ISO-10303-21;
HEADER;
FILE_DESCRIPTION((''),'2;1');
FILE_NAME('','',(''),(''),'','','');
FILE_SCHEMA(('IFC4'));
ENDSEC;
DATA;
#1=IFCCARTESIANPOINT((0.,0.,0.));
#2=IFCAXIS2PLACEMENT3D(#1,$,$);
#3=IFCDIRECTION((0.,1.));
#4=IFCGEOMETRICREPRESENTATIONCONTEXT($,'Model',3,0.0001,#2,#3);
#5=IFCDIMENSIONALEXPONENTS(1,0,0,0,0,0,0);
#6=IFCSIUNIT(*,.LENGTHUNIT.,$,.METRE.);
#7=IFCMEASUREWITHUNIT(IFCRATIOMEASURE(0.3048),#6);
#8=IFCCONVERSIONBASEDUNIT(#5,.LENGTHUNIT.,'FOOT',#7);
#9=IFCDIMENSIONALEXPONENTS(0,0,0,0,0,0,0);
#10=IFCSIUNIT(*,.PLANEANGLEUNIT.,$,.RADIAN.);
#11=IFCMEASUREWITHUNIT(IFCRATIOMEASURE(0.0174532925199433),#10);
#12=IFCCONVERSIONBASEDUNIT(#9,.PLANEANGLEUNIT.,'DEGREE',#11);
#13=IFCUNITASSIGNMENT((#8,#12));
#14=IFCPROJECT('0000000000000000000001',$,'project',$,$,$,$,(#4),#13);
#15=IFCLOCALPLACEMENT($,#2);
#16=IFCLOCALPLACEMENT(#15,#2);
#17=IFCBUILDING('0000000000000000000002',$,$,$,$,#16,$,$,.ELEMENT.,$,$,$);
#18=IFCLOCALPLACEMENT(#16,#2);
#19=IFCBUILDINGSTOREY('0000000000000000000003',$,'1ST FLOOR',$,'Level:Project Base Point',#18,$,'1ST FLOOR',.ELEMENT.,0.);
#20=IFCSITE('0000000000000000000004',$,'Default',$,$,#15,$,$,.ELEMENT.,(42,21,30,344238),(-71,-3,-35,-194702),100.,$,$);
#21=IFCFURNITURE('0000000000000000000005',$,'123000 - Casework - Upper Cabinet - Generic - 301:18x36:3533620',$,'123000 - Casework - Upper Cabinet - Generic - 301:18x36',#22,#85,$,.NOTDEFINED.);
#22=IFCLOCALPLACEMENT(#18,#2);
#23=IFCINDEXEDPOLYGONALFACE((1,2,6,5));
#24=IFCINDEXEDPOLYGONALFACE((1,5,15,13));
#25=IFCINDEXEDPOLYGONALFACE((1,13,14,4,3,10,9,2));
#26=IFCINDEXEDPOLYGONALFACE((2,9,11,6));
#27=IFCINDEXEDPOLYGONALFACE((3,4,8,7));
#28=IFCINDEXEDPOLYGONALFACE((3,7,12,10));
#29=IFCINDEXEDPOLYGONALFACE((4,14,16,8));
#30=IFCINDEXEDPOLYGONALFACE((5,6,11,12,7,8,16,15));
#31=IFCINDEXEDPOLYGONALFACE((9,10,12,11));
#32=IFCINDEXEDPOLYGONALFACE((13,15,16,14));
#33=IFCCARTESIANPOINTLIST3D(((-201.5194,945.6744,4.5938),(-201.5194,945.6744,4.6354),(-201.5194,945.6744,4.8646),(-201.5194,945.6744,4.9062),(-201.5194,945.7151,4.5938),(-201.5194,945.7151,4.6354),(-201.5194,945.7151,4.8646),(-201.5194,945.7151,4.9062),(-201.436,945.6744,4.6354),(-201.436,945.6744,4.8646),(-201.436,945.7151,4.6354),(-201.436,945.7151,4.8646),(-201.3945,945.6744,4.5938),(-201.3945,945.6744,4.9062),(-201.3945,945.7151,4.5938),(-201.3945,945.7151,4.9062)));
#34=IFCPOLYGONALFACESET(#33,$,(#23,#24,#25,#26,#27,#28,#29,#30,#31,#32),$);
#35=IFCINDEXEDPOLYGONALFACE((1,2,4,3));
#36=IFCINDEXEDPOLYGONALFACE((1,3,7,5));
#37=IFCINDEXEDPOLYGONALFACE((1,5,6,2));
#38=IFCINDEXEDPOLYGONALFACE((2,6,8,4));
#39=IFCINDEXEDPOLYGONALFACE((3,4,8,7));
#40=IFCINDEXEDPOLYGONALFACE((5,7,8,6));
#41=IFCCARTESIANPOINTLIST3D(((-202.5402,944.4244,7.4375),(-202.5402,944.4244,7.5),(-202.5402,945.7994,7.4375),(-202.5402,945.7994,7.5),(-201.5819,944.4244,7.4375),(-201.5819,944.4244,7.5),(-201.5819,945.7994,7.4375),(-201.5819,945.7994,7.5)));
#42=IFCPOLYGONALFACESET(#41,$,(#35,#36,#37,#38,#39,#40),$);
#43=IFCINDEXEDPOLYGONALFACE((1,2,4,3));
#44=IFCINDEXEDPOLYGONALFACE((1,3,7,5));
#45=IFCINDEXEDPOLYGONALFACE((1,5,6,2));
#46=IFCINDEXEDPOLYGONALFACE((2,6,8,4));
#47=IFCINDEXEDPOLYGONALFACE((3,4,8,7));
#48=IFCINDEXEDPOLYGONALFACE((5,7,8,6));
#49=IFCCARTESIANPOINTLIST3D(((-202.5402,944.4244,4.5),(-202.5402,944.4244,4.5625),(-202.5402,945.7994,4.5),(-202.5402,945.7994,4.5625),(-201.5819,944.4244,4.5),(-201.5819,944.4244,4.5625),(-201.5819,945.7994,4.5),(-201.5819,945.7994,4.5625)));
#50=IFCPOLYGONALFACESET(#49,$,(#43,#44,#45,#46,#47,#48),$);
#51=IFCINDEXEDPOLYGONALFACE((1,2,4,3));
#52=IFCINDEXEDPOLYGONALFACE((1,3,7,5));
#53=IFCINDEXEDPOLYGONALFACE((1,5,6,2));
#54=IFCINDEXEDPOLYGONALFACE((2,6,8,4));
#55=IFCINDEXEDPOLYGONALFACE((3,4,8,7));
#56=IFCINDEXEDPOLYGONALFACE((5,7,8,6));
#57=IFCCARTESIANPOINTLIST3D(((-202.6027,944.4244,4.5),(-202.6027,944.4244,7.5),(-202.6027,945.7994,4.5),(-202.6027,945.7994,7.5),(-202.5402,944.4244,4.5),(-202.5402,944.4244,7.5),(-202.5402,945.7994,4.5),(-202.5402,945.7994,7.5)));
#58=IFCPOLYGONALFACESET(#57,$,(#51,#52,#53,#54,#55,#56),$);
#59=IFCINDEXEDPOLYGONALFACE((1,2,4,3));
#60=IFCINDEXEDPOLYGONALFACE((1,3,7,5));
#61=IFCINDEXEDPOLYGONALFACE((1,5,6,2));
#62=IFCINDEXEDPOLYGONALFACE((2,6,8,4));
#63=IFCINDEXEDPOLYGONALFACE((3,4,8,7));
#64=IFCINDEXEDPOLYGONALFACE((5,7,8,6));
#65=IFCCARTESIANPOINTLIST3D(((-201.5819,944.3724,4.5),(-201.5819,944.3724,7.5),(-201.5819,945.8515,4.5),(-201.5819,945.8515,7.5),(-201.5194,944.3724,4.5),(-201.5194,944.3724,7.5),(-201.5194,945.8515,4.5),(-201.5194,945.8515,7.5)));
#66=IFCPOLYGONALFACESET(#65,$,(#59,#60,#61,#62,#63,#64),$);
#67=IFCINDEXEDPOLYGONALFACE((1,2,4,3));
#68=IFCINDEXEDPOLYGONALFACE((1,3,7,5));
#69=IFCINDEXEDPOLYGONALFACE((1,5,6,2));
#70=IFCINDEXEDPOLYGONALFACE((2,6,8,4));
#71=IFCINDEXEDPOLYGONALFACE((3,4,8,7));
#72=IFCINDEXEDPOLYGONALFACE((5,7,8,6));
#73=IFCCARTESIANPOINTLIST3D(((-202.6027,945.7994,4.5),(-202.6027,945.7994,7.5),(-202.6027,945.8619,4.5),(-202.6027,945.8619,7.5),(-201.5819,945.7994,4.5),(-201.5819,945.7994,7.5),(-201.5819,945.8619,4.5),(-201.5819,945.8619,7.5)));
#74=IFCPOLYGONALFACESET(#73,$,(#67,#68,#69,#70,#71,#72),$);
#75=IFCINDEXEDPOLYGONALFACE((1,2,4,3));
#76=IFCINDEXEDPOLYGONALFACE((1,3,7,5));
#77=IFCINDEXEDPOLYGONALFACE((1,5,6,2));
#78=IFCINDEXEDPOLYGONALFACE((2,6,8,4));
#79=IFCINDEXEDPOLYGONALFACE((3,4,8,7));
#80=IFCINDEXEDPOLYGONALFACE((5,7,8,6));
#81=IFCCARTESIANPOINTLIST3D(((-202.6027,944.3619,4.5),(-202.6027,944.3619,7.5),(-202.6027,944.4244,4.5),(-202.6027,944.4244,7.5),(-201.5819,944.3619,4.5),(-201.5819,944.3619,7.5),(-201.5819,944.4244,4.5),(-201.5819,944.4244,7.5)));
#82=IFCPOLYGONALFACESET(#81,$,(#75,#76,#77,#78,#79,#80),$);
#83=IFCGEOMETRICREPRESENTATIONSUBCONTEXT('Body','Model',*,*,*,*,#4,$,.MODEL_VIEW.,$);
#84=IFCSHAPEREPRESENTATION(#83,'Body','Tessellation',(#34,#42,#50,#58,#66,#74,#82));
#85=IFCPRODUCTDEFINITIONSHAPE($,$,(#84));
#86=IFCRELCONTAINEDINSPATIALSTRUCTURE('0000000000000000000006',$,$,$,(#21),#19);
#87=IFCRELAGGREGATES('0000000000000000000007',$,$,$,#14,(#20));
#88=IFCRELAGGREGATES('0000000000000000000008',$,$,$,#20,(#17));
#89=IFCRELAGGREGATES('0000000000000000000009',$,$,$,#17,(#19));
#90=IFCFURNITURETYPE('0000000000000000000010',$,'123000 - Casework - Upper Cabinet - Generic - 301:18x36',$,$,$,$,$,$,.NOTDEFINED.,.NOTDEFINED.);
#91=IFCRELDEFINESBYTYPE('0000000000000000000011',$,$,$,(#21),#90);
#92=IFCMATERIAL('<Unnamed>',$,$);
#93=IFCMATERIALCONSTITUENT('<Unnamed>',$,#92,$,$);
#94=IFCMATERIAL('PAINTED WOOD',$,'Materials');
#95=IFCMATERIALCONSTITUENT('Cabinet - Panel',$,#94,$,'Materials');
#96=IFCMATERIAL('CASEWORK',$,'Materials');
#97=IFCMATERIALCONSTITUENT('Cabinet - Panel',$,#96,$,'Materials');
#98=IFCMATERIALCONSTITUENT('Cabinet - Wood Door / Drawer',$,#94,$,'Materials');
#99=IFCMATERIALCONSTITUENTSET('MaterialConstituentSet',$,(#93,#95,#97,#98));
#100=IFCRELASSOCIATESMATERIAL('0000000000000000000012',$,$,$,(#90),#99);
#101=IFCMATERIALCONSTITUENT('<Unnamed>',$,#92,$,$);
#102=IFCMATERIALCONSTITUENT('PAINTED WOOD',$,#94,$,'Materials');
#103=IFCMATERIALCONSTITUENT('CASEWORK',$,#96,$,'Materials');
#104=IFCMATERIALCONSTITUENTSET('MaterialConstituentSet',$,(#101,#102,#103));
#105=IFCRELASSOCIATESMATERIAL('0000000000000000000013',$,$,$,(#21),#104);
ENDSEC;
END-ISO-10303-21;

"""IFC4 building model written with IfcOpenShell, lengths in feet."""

from ifc_helpers import new_model, entity, si_unit, converted_unit, direction, frame, frame_2d, origin, origin_2d_with_axis, place, context, subcontext, project, spatial, polyline, rectangle, outline, extrude, source, transform, mapped, material, constituent, constituent_set, type_object, type_shapes, element, save


model = new_model("IFC4")

# Units and contexts
model_context = context("Model", 3, precision=0.0001, world=origin(), true_north=direction((0.0, 1.0)))
body_context = subcontext(model_context, "Body", "Model", "MODEL_VIEW")
ifc_project = project(units=[converted_unit("LENGTHUNIT", "FOOT", entity("IfcRatioMeasure", 0.3048), si_unit("LENGTHUNIT", "METRE"), dimensions=[1, 0, 0, 0, 0, 0, 0]), converted_unit("PLANEANGLEUNIT", "DEGREE", entity("IfcRatioMeasure", 0.0174532925199433), si_unit("PLANEANGLEUNIT", "RADIAN"), dimensions=[0, 0, 0, 0, 0, 0, 0])], contexts=[model_context])

# Site, building, storey
site_placement = place(None, origin())
site = spatial("IfcSite", under=ifc_project, at=site_placement, Name="Default", CompositionType="ELEMENT", RefLatitude=(42, 21, 30, 344238), RefLongitude=(-71, -3, -35, -194702), RefElevation=100.0)
building_placement = place(site_placement, origin())
building = spatial("IfcBuilding", under=site, at=building_placement, CompositionType="ELEMENT")
storey_placement = place(building_placement, origin())
storey = spatial("IfcBuildingStorey", under=building, at=storey_placement, Name="1ST FLOOR", ObjectType="Level:Project Base Point", LongName="1ST FLOOR", CompositionType="ELEMENT", Elevation=0.0)

# Shared definitions
ifc_material_1 = material(Name="<Unnamed>")

# Shared definitions
ifc_material_2 = material(Name="PAINTED WOOD", Category="Materials")
ifc_material_3 = material(Name="CASEWORK", Category="Materials")

# Furniture
ifc_constituent_1 = constituent(ifc_material_1, Name="<Unnamed>")
ifc_constituent_2 = constituent(ifc_material_2, Name="PAINTED WOOD", Category="Materials")
ifc_constituent_3 = constituent(ifc_material_3, Name="CASEWORK", Category="Materials")
ifc_constituent_set_1 = constituent_set(constituents=[ifc_constituent_1, ifc_constituent_2, ifc_constituent_3], Name="MaterialConstituentSet")
ifc_constituent_4 = constituent(ifc_material_1, Name="<Unnamed>")
ifc_constituent_5 = constituent(ifc_material_2, Name="Cabinet - Panel", Category="Materials")
ifc_constituent_6 = constituent(ifc_material_3, Name="Cabinet - Panel", Category="Materials")
ifc_constituent_7 = constituent(ifc_material_2, Name="Cabinet - Wood Door / Drawer", Category="Materials")
ifc_constituent_set_2 = constituent_set(constituents=[ifc_constituent_4, ifc_constituent_5, ifc_constituent_6, ifc_constituent_7], Name="MaterialConstituentSet")
furniture_type_1 = type_object("IfcFurnitureType", Name="123000 - Casework - Upper Cabinet - Generic - 301:18x36", AssemblyPlace="NOTDEFINED", PredefinedType="NOTDEFINED", material=ifc_constituent_set_2)
shared_shape_1 = source(origin(), body_context, "Body", "SweptSolid", [
    extrude(outline(polyline([(-0.0521, -0.1146), (-0.0521, -0.1562), (0.0729, -0.1562), (0.0729, 0.1562), (-0.0521, 0.1562), (-0.0521, 0.1146), (0.0313, 0.1146), (0.0313, -0.1146), (-0.0521, -0.1146)])), frame((0.1468, 1.1354, 0.25), z_axis=(-1.0, 0.0, 0.0), x_axis=(0.0, 1.0, 0.0)), (0.0, 0.0, -1.0), 0.0407),
    extrude(rectangle(XDim=0.9583, YDim=1.375, at=frame_2d((0.0, 0.0), x_axis=(1.0, 0.0))), frame((0.75, 0.5417, 2.9375), z_axis=(0.0, 0.0, 1.0), x_axis=(0.0, 1.0, 0.0)), (0.0, 0.0, 1.0), 0.0625),
    extrude(rectangle(XDim=0.9583, YDim=1.375, at=frame_2d((0.0, 0.0), x_axis=(1.0, 0.0))), frame((0.75, 0.5417, 0.0), z_axis=(0.0, 0.0, 1.0), x_axis=(0.0, 1.0, 0.0)), (0.0, 0.0, 1.0), 0.0625),
    extrude(rectangle(XDim=1.375, YDim=0.0625, at=origin_2d_with_axis()), frame((0.75, 0.0313, 0.0), z_axis=(0.0, 0.0, 1.0), x_axis=(-1.0, 0.0, 0.0)), (0.0, 0.0, 1.0), 3.0),
    extrude(rectangle(XDim=1.4792, YDim=0.0625, at=origin_2d_with_axis()), frame((0.75, 1.0521, 0.0)), (0.0, 0.0, 1.0), 3.0),
    extrude(rectangle(XDim=1.0208, YDim=0.0625, at=origin_2d_with_axis()), frame((0.0312, 0.5104, 0.0), z_axis=(0.0, 0.0, 1.0), x_axis=(0.0, 1.0, 0.0)), (0.0, 0.0, 1.0), 3.0),
    extrude(rectangle(XDim=1.0208, YDim=0.0625, at=origin_2d_with_axis()), frame((1.4688, 0.5104, 0.0), z_axis=(0.0, 0.0, 1.0), x_axis=(0.0, 1.0, 0.0)), (0.0, 0.0, 1.0), 3.0),
])
type_shapes(furniture_type_1, [shared_shape_1])
furniture_1_placement = place(storey_placement, frame((-202.6027, 945.8619, 4.5), z_axis=(0.0, 0.0, 1.0), x_axis=(0.0, -1.0, 0.0)))
element("IfcFurniture", 1, at=furniture_1_placement, inside=storey, type_object=furniture_type_1, material=ifc_constituent_set_1, Name="123000 - Casework - Upper Cabinet - Generic - 301:18x36:3533620", ObjectType="123000 - Casework - Upper Cabinet - Generic - 301:18x36", PredefinedType="NOTDEFINED", context=body_context, shape_type="MappedRepresentation", body=[
    mapped(shared_shape_1, transform((0.0, 0.0, 0.0), scale=1.0)),
])

save(model, "model.ifc")
